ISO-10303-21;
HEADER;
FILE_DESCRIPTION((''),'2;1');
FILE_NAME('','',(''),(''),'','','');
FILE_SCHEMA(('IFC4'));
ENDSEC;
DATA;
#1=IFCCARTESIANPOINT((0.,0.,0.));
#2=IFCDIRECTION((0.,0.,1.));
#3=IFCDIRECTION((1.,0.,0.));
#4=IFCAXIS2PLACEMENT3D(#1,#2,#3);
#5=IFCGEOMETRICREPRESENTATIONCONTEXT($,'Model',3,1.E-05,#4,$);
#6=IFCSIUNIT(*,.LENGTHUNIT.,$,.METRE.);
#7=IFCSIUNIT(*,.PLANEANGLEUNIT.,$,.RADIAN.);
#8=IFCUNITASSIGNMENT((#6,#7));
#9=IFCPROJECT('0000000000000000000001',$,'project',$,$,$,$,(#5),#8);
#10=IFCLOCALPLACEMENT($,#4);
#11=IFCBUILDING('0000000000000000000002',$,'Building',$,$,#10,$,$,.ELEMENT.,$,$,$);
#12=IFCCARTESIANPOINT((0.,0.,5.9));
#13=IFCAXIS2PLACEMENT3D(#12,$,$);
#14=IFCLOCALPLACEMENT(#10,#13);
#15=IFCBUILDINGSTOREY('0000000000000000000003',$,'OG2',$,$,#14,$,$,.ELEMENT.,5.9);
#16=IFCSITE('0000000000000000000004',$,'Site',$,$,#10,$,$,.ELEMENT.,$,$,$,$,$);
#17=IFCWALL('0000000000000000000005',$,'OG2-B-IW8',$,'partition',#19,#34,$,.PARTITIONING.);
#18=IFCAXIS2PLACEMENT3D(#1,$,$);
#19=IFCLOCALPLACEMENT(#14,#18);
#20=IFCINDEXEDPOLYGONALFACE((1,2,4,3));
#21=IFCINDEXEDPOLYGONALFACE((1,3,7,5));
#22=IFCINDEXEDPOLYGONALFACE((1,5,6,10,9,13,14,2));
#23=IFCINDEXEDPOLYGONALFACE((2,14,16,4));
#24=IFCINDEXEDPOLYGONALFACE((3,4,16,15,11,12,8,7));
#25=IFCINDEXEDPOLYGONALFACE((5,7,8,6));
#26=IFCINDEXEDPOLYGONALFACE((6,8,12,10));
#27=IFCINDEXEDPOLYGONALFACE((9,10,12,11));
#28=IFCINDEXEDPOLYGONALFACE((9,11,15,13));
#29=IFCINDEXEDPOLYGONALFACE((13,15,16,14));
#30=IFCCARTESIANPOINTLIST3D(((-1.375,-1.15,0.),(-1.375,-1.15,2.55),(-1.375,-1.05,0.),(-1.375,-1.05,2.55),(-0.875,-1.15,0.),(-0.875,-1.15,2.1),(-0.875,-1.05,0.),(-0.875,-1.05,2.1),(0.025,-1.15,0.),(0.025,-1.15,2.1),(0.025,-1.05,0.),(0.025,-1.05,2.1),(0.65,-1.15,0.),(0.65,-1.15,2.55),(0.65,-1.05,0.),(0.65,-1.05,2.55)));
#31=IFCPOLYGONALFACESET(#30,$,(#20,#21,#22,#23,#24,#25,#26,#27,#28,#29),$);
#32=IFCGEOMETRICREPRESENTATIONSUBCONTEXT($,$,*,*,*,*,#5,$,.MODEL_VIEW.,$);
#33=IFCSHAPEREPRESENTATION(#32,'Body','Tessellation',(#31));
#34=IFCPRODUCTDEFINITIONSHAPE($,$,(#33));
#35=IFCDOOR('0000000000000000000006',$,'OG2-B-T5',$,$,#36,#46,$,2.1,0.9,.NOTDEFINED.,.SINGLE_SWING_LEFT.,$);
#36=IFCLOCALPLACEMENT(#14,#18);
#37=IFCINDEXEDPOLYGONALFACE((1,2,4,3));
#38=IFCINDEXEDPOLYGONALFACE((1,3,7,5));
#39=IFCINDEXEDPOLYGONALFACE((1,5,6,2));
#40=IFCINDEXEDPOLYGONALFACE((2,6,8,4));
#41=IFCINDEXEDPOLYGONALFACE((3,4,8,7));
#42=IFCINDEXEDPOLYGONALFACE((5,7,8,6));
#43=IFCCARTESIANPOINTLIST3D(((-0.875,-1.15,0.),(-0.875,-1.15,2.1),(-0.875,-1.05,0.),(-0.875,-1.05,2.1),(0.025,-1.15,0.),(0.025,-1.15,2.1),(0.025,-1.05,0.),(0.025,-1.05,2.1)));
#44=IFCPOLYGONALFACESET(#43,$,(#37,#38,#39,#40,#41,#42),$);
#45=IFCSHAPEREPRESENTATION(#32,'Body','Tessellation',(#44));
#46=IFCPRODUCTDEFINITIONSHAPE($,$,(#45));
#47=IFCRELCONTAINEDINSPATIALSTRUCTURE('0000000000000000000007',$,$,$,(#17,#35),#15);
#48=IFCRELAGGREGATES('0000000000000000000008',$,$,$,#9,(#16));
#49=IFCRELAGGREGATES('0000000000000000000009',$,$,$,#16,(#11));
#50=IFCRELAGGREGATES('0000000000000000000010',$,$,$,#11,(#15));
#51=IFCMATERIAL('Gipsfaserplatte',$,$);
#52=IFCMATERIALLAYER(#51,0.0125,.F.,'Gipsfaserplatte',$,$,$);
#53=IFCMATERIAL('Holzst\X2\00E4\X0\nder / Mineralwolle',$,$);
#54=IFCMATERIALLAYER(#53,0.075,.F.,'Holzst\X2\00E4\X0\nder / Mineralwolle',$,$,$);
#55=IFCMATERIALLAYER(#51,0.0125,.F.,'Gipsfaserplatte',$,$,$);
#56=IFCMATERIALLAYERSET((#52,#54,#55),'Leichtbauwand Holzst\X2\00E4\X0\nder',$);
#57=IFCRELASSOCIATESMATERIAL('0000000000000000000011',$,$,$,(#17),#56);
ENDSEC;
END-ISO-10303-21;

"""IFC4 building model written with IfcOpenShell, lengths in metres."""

from ifc_helpers import new_model, si_unit, frame, frame_2d, origin, origin_with_axes, place, context, subcontext, project, spatial, rectangle, extrude, material, layer, layer_set, element, fill, save


model = new_model("IFC4")

# Units and contexts
model_context = context("Model", 3, precision=1e-05, world=origin_with_axes())
sub_context = subcontext(model_context, None, None, "MODEL_VIEW")
ifc_project = project(units=[si_unit("LENGTHUNIT", "METRE"), si_unit("PLANEANGLEUNIT", "RADIAN")], contexts=[model_context])

# Site, building, storey
placement = place(None, origin_with_axes())
site = spatial("IfcSite", under=ifc_project, at=placement, Name="Site", CompositionType="ELEMENT")
building = spatial("IfcBuilding", under=site, at=placement, Name="Building", CompositionType="ELEMENT")
storey_placement = place(placement, frame((0.0, 0.0, 5.9)))
storey = spatial("IfcBuildingStorey", under=building, at=storey_placement, Name="OG2", CompositionType="ELEMENT", Elevation=5.9)

# Shared definitions
ifc_material_1 = material(Name="Gipsfaserplatte")

# Shared definitions
ifc_material_2 = material(Name="Holzständer / Mineralwolle")

# Wall, opening, door
ifc_layer_1 = layer(ifc_material_1, 0.0125, ventilated=False, Name="Gipsfaserplatte")
ifc_layer_2 = layer(ifc_material_2, 0.075, ventilated=False, Name="Holzständer / Mineralwolle")
ifc_layer_3 = layer(ifc_material_1, 0.0125, ventilated=False, Name="Gipsfaserplatte")
ifc_layer_set_1 = layer_set([ifc_layer_1, ifc_layer_2, ifc_layer_3], Name="Leichtbauwand Holzständer")
wall_1_placement = place(storey_placement, frame((-1.375, -1.1, 0.0), z_axis=(0.0, 0.0, 1.0), x_axis=(1.0, 0.0, 0.0)))
wall_1 = element("IfcWall", 1, at=wall_1_placement, inside=storey, material=ifc_layer_set_1, Name="OG2-B-IW8", ObjectType="partition", PredefinedType="PARTITIONING", context=sub_context, shape_type="SweptSolid", body=[
    extrude(rectangle(XDim=2.025, YDim=0.1, at=frame_2d((1.0125, 0.0))), origin(), (0.0, 0.0, 1.0), 2.55),
])
opening_1_placement = place(wall_1_placement, frame((0.95, 0.1, 0.0), z_axis=(0.0, -1.0, 0.0), x_axis=(1.0, 0.0, 0.0)))
opening_1 = element("IfcOpeningElement", 2, at=opening_1_placement, cuts=wall_1, PredefinedType="OPENING", context=sub_context, shape_type="SweptSolid", body=[
    extrude(rectangle(XDim=0.9, YDim=2.1, at=frame_2d((0.0, 1.05))), origin(), (0.0, 0.0, 1.0), 0.2),
])
door_1_placement = place(wall_1_placement, frame((0.95, 0.05, 0.0), z_axis=(0.0, -1.0, 0.0), x_axis=(1.0, 0.0, 0.0)))
door_1 = element("IfcDoor", 3, at=door_1_placement, inside=storey, Name="OG2-B-T5", OperationType="SINGLE_SWING_LEFT", OverallHeight=2.1, OverallWidth=0.9, PredefinedType="NOTDEFINED", context=sub_context, shape_type="SweptSolid", body=[
    extrude(rectangle(XDim=0.9, YDim=2.1, at=frame_2d((0.0, 1.05))), origin(), (0.0, 0.0, 1.0), 0.1),
])
fill(opening_1, door_1)

save(model, "model.ifc")
